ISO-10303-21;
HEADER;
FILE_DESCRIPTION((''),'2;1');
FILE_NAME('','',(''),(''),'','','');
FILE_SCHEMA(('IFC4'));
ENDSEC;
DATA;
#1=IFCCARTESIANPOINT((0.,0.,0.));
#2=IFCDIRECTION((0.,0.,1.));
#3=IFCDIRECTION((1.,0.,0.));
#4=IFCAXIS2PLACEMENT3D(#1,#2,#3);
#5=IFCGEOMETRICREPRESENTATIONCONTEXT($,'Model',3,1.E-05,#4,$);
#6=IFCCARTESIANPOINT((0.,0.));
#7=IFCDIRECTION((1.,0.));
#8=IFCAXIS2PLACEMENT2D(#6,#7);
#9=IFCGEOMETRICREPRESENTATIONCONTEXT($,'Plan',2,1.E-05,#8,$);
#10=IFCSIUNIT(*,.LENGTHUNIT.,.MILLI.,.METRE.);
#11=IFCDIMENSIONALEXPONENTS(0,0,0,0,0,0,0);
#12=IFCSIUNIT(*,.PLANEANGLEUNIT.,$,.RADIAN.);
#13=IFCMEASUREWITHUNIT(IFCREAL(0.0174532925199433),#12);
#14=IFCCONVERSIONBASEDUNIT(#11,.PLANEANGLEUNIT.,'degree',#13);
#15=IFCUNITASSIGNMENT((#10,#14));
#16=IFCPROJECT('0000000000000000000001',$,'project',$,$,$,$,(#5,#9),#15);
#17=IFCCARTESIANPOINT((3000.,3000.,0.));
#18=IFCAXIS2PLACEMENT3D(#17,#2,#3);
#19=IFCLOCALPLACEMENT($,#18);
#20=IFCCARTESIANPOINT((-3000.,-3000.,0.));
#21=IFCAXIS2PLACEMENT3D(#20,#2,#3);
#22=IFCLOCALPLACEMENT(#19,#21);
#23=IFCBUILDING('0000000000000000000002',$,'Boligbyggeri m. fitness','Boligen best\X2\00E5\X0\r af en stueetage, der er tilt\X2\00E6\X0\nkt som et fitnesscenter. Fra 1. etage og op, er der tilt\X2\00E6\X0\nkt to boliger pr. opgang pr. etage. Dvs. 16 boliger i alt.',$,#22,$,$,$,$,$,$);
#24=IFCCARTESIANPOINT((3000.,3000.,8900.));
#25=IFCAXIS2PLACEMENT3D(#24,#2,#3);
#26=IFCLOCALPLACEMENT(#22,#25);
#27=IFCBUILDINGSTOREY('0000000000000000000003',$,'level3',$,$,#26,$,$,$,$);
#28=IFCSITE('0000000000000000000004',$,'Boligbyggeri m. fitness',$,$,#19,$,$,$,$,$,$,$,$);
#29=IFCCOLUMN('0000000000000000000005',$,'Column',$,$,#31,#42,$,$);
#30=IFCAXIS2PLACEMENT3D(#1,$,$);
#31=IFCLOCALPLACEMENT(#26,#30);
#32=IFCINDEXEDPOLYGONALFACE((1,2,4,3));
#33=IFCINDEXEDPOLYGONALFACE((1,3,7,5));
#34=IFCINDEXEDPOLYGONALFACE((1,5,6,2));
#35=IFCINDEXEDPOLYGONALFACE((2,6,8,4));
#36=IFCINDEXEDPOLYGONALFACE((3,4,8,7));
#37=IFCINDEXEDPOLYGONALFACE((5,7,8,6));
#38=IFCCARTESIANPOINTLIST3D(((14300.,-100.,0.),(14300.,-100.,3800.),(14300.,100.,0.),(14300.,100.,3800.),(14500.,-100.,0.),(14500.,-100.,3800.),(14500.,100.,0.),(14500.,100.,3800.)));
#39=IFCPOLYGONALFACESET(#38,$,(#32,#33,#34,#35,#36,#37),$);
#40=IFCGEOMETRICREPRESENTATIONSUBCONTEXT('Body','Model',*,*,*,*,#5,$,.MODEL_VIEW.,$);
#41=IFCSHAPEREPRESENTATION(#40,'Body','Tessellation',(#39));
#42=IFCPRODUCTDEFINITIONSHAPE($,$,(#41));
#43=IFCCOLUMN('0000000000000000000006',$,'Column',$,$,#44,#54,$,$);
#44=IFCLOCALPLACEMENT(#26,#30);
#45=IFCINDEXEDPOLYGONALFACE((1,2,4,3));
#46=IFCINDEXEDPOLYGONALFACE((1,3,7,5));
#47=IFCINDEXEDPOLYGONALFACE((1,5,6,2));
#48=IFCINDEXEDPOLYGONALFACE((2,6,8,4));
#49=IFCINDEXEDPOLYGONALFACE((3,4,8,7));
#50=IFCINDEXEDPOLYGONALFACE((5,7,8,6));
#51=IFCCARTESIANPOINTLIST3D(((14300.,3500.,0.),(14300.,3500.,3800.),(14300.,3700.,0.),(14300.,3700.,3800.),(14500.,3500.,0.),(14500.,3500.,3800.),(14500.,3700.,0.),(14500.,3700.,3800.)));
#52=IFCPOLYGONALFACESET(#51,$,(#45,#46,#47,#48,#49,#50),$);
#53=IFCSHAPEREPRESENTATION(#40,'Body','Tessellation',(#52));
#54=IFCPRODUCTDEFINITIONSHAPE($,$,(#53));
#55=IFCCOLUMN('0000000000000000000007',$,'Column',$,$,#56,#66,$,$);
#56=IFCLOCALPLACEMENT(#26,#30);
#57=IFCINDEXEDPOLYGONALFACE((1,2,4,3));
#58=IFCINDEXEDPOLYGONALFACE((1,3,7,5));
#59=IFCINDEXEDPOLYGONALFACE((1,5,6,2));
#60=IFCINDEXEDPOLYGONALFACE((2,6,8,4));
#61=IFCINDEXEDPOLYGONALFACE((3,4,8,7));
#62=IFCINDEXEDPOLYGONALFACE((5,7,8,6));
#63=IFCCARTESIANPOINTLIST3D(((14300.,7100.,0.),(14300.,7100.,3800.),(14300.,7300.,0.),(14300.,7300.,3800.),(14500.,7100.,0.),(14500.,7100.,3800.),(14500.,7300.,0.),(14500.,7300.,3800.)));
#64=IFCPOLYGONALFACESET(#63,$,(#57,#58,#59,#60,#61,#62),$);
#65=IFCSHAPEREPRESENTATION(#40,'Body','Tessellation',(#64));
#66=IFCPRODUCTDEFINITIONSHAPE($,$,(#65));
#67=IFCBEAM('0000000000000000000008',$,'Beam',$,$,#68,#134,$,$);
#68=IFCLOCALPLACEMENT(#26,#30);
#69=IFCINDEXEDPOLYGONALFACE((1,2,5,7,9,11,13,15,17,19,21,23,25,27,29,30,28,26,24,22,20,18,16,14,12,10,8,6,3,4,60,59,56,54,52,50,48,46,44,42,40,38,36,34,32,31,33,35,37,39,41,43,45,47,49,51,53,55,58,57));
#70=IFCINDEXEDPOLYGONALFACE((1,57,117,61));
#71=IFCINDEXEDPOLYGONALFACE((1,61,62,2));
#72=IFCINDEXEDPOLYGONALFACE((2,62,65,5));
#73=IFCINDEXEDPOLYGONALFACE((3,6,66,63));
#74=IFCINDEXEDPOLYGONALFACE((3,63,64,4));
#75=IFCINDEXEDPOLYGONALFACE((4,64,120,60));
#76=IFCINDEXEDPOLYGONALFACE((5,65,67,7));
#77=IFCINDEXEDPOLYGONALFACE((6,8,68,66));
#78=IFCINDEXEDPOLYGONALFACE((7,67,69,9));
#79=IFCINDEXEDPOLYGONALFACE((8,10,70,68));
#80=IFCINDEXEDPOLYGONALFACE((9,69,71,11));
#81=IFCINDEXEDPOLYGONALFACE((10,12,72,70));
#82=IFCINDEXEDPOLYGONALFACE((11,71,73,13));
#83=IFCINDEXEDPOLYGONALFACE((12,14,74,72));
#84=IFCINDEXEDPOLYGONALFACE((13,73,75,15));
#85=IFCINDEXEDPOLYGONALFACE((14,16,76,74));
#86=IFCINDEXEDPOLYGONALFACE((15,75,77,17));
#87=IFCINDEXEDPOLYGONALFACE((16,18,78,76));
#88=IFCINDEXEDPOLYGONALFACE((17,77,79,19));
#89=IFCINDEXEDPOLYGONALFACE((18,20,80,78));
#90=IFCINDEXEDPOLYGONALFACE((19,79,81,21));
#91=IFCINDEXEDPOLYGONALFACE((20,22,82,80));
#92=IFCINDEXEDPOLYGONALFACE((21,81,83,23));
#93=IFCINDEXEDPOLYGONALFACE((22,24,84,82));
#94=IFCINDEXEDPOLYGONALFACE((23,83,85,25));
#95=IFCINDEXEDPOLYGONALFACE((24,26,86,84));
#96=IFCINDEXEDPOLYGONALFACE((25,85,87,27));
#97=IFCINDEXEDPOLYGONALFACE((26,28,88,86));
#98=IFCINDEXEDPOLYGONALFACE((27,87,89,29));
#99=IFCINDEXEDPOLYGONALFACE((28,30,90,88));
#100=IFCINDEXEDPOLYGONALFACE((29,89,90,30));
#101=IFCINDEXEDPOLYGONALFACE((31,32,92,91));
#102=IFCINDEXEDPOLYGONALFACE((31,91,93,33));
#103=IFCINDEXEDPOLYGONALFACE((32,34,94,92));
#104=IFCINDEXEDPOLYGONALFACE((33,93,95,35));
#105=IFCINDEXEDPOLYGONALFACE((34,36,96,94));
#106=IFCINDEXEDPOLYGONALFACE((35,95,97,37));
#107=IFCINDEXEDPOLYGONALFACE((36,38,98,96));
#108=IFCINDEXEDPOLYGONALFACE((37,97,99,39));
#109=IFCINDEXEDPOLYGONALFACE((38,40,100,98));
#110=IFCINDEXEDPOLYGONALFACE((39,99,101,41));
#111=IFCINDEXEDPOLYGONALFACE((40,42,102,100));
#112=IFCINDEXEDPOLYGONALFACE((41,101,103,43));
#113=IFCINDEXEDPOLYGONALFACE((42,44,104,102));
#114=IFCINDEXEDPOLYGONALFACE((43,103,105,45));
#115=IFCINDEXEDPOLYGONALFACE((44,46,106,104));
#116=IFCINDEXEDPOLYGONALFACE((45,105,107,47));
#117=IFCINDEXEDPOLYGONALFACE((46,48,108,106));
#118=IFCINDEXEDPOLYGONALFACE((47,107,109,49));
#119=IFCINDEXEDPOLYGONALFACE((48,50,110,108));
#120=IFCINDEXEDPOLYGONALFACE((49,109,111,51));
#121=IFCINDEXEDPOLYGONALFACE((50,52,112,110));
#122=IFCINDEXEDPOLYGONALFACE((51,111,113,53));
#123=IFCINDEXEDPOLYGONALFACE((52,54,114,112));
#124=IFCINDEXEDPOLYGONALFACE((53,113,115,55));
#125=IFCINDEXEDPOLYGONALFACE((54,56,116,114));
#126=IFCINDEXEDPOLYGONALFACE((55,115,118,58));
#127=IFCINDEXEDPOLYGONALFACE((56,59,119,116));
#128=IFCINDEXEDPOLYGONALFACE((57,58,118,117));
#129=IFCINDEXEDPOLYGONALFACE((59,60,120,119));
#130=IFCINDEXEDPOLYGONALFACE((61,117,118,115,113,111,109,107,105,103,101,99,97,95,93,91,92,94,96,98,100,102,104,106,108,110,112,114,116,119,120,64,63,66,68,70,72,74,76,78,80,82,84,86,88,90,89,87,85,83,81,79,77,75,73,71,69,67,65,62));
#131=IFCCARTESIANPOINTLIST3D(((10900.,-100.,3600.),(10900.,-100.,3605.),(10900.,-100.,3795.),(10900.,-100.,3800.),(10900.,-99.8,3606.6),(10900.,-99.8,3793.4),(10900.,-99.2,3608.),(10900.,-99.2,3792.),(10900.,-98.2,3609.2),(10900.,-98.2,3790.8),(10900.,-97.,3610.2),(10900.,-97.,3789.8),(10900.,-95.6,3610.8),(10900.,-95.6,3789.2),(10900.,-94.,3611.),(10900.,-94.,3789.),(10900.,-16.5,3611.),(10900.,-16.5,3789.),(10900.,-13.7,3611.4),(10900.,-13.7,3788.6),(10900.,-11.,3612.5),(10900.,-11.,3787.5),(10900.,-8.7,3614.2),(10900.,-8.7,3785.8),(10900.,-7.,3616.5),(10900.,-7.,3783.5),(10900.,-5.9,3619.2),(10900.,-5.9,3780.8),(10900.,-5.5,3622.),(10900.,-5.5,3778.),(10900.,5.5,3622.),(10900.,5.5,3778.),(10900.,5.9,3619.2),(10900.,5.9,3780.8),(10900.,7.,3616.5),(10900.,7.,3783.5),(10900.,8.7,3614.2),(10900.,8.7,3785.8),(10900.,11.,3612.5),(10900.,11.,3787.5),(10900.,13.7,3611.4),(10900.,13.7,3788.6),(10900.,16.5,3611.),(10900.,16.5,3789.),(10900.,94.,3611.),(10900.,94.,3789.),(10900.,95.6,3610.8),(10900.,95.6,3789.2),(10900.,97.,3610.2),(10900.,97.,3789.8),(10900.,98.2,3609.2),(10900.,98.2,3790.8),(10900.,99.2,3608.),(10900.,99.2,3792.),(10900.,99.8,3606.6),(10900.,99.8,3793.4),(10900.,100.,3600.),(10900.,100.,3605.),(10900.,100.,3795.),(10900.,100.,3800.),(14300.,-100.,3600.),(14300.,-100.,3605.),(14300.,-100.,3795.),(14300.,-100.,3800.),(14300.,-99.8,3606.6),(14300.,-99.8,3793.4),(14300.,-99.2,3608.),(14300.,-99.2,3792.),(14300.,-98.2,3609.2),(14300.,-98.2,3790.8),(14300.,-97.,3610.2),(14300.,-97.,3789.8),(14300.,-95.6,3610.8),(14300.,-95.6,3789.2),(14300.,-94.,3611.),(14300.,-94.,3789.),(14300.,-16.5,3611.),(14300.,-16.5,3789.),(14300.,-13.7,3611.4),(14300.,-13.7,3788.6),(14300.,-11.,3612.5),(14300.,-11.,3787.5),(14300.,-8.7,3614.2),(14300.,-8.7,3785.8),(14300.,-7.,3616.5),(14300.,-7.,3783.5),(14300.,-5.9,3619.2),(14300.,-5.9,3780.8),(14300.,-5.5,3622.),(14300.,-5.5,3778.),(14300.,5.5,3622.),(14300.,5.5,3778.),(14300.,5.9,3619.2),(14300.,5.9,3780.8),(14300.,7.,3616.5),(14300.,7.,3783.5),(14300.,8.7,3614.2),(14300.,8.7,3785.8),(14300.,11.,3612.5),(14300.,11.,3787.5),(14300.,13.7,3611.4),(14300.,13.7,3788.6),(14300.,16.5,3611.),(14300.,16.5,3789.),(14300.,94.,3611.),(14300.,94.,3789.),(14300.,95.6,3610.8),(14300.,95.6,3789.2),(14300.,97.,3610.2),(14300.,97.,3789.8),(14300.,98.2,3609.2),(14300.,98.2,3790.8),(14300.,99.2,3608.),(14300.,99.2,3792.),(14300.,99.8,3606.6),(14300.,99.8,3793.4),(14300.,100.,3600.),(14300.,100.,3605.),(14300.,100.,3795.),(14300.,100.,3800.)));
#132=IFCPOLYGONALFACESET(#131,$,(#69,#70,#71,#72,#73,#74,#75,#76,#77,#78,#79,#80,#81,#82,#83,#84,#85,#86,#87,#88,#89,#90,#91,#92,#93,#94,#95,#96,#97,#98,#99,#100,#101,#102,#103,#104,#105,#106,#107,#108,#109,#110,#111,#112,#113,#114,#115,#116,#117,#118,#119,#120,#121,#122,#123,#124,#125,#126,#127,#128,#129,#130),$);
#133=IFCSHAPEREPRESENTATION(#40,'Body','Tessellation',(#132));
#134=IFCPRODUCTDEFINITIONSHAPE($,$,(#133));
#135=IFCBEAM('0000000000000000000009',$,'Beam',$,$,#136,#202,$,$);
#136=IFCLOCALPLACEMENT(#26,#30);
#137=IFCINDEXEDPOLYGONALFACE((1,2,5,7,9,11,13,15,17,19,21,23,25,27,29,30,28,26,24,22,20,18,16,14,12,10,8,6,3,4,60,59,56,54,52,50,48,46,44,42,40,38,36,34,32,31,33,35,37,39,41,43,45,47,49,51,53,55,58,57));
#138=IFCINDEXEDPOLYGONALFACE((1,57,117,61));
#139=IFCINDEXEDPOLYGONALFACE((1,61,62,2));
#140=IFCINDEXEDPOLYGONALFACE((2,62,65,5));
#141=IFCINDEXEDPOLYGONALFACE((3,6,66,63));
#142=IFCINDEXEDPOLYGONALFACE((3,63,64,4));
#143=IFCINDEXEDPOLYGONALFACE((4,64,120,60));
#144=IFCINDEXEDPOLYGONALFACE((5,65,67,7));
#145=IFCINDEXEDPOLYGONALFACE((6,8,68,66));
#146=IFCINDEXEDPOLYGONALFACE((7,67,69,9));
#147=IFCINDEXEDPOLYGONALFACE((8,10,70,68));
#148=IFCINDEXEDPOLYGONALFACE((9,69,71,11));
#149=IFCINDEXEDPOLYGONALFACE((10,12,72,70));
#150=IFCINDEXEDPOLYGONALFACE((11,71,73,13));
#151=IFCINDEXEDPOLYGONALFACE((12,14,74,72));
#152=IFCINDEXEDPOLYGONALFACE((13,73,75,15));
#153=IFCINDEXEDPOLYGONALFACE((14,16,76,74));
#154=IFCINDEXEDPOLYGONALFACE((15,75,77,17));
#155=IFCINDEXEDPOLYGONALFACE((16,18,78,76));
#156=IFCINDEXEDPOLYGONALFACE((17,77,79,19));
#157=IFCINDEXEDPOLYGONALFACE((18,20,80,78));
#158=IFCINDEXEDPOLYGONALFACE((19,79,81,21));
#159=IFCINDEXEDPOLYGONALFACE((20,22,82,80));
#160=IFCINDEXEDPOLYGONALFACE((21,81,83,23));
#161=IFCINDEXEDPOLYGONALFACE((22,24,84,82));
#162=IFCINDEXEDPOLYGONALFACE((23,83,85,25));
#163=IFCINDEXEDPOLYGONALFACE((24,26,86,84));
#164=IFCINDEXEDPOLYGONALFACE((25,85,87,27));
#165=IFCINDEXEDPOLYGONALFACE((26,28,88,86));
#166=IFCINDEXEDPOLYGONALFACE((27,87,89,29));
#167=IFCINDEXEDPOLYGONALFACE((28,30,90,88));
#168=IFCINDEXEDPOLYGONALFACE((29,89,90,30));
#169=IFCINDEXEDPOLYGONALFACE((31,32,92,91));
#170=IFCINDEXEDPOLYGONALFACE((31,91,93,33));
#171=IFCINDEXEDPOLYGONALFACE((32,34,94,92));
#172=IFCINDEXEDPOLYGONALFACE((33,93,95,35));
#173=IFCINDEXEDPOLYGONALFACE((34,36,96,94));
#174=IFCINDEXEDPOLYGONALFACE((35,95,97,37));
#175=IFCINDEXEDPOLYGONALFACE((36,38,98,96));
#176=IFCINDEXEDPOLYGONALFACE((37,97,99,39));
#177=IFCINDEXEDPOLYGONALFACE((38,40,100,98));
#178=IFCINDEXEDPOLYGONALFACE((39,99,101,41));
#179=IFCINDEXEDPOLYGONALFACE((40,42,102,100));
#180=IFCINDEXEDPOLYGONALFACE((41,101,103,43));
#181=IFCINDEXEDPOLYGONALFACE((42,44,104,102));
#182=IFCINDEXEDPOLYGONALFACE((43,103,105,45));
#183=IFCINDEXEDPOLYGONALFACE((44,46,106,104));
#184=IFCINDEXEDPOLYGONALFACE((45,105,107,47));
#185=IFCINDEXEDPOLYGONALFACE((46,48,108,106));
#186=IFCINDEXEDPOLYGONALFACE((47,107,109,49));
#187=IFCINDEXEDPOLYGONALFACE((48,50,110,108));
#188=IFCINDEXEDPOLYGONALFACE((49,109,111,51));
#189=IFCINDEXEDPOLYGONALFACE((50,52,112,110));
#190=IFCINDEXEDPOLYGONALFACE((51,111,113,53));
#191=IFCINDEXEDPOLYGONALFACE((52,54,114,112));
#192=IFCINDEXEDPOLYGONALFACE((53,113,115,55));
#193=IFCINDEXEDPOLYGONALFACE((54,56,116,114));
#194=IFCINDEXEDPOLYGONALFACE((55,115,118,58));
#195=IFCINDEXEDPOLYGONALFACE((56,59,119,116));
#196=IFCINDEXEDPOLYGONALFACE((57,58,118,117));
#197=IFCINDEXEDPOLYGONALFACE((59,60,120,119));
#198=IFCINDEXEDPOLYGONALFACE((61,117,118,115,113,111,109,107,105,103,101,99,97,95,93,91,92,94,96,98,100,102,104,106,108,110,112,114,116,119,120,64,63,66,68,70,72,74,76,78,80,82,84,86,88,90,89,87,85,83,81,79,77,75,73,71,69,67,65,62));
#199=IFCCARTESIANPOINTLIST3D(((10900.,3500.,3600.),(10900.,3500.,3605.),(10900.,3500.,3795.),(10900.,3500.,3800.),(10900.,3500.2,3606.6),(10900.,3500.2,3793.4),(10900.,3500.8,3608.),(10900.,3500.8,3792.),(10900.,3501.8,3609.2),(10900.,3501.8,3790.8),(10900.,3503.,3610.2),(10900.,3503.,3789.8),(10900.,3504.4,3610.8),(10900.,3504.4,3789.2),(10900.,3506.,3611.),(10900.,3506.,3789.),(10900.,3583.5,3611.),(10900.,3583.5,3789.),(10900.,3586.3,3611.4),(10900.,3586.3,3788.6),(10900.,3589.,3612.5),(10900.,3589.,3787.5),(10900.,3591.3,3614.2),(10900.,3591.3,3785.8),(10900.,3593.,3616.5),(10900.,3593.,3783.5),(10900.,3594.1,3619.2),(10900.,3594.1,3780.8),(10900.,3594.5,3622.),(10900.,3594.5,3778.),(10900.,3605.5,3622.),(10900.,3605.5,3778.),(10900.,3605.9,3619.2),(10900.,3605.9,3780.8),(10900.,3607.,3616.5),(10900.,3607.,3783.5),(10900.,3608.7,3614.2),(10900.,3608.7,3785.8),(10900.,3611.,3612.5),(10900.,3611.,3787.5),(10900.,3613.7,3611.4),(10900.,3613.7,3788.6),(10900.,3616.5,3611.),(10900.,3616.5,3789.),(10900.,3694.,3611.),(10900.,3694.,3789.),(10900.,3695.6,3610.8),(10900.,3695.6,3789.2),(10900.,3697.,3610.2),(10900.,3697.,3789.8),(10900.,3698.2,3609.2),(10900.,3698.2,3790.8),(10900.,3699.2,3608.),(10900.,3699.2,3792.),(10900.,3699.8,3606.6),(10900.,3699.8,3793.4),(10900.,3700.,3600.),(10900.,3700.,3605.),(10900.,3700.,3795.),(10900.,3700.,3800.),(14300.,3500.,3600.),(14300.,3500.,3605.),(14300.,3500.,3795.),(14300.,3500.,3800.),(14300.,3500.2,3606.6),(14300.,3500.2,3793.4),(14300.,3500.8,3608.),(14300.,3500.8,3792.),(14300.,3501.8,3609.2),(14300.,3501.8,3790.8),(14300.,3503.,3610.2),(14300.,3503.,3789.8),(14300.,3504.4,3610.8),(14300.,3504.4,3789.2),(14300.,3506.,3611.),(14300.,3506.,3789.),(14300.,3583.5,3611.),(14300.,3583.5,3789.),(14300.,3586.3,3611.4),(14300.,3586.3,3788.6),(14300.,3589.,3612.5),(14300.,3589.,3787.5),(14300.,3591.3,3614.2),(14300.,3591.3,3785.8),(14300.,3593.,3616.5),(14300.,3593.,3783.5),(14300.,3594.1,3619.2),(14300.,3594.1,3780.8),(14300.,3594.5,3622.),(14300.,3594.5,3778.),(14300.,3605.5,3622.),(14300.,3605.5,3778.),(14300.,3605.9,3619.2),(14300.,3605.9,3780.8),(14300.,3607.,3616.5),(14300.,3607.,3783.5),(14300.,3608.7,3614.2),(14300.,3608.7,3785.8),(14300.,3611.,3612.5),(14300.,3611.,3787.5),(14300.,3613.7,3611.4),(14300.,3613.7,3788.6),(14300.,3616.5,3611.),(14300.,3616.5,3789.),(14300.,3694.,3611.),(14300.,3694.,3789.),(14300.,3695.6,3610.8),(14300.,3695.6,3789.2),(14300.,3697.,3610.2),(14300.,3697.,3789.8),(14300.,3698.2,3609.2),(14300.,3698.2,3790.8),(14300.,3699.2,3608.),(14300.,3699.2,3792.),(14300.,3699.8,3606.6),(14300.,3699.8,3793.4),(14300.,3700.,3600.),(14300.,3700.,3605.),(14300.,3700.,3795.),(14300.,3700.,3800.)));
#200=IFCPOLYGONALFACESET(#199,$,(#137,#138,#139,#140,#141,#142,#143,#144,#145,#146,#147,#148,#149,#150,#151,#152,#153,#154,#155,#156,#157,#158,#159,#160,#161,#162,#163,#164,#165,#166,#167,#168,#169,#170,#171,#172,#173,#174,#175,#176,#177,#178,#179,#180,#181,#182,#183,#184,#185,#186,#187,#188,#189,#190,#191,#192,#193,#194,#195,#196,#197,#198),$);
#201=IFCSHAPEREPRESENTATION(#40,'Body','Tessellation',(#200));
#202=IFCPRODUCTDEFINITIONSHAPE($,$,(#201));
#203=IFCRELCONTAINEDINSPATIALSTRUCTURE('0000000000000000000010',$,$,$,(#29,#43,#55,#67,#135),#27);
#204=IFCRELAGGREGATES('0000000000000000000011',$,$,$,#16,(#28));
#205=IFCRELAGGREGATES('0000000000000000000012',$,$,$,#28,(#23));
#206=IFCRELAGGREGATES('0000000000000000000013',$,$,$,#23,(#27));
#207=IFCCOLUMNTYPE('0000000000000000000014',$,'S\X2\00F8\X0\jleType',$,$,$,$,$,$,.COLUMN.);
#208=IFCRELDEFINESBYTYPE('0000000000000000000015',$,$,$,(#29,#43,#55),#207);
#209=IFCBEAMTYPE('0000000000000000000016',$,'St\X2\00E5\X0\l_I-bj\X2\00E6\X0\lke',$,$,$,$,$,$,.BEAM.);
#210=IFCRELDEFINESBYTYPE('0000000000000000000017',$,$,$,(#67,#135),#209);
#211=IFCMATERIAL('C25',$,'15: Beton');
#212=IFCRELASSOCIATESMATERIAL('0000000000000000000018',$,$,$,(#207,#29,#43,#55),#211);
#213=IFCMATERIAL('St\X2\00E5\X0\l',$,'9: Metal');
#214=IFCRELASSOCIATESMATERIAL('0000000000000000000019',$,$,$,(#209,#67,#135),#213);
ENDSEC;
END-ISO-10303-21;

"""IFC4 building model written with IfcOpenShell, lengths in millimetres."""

from ifc_helpers import new_model, entity, si_unit, converted_unit, frame, origin_with_axes, origin_2d_with_axis, place, context, subcontext, project, spatial, rectangle, i_section, extrude, material, material_profile, profile_set, profile_usage, type_object, element, save


model = new_model("IFC4")

# Units and contexts
model_context = context("Model", 3, precision=1e-05, world=origin_with_axes())
plan_context = context("Plan", 2, precision=1e-05, world=origin_2d_with_axis())
body_context = subcontext(model_context, "Body", "Model", "MODEL_VIEW")
ifc_project = project(units=[si_unit("LENGTHUNIT", "METRE", prefix="MILLI"), converted_unit("PLANEANGLEUNIT", "degree", entity("IfcReal", 0.0174532925199433), si_unit("PLANEANGLEUNIT", "RADIAN"), dimensions=[0, 0, 0, 0, 0, 0, 0])], contexts=[model_context, plan_context])

# Site, building, storey
site_placement = place(None, frame((3000.0, 3000.0, 0.0), z_axis=(0.0, 0.0, 1.0), x_axis=(1.0, 0.0, 0.0)))
site = spatial("IfcSite", under=ifc_project, at=site_placement, Name="Boligbyggeri m. fitness")
building_placement = place(site_placement, frame((-3000.0, -3000.0, 0.0), z_axis=(0.0, 0.0, 1.0), x_axis=(1.0, 0.0, 0.0)))
building = spatial("IfcBuilding", under=site, at=building_placement, Name="Boligbyggeri m. fitness", Description="Boligen består af en stueetage, der er tiltænkt som et fitnesscenter. Fra 1. etage og op, er der tiltænkt to boliger pr. opgang pr. etage. Dvs. 16 boliger i alt.")
storey_placement = place(building_placement, frame((3000.0, 3000.0, 8900.0), z_axis=(0.0, 0.0, 1.0), x_axis=(1.0, 0.0, 0.0)))
storey = spatial("IfcBuildingStorey", under=building, at=storey_placement, Name="level3")

# Columns
ifc_material_1 = material(Name="C25", Category="15: Beton")
ifc_material_profile_1 = material_profile(ifc_material_1, rectangle(XDim=200.0, YDim=200.0), Name="SøjleBeton", Category="15: Beton")
ifc_profile_set_1 = profile_set([ifc_material_profile_1], Name="200x200")
ifc_profile_usage_1 = profile_usage(ifc_profile_set_1, cardinal=5)
column_type = type_object("IfcColumnType", Name="SøjleType", PredefinedType="COLUMN", material=ifc_profile_set_1)
column_1_placement = place(storey_placement, frame((14400.0, 0.0, 0.0), z_axis=(0.0, 0.0, 1.0), x_axis=(1.0, 0.0, 0.0)))
element("IfcColumn", 1, at=column_1_placement, inside=storey, type_object=column_type, material=ifc_profile_usage_1, Name="Column", context=body_context, shape_type="SweptSolid", body=[
    extrude(rectangle(XDim=200.0, YDim=200.0), origin_with_axes(), (0.0, 0.0, 1.0), 3800.0),
])
ifc_profile_usage_2 = profile_usage(ifc_profile_set_1, cardinal=5)
column_2_placement = place(storey_placement, frame((14400.0, 3600.0, 0.0), z_axis=(0.0, 0.0, 1.0), x_axis=(1.0, 0.0, 0.0)))
element("IfcColumn", 2, at=column_2_placement, inside=storey, type_object=column_type, material=ifc_profile_usage_2, Name="Column", context=body_context, shape_type="SweptSolid", body=[
    extrude(rectangle(XDim=200.0, YDim=200.0), origin_with_axes(), (0.0, 0.0, 1.0), 3800.0),
])
ifc_profile_usage_3 = profile_usage(ifc_profile_set_1, cardinal=5)
column_3_placement = place(storey_placement, frame((14400.0, 7200.0, 0.0), z_axis=(0.0, 0.0, 1.0), x_axis=(1.0, 0.0, 0.0)))
element("IfcColumn", 3, at=column_3_placement, inside=storey, type_object=column_type, material=ifc_profile_usage_3, Name="Column", context=body_context, shape_type="SweptSolid", body=[
    extrude(rectangle(XDim=200.0, YDim=200.0), origin_with_axes(), (0.0, 0.0, 1.0), 3800.0),
])

# Beams
ifc_material_2 = material(Name="Stål", Category="9: Metal")
ifc_material_profile_2 = material_profile(ifc_material_2, i_section(OverallWidth=200.0, OverallDepth=200.0, WebThickness=11.0, FlangeThickness=11.0, FilletRadius=11.0, FlangeEdgeRadius=6.0), Name="Stål", Category="9: Metal")
ifc_profile_set_2 = profile_set([ifc_material_profile_2], Name="NY_I-Profil")
ifc_profile_usage_4 = profile_usage(ifc_profile_set_2, cardinal=7)
beam_type = type_object("IfcBeamType", Name="Stål_I-bjælke", PredefinedType="BEAM", material=ifc_profile_set_2)
beam_1_placement = place(storey_placement, frame((10900.0, 100.0, 3800.0), z_axis=(1.0, 0.0, 0.0), x_axis=(0.0, 1.0, 0.0)))
element("IfcBeam", 4, at=beam_1_placement, inside=storey, type_object=beam_type, material=ifc_profile_usage_4, Name="Beam", context=body_context, shape_type="SweptSolid", body=[
    extrude(i_section(OverallWidth=200.0, OverallDepth=200.0, WebThickness=11.0, FlangeThickness=11.0, FilletRadius=11.0, FlangeEdgeRadius=6.0), frame((-100.0, -100.0, 0.0), z_axis=(0.0, 0.0, 1.0), x_axis=(1.0, 0.0, 0.0)), (0.0, 0.0, 1.0), 3400.0),
])
ifc_profile_usage_5 = profile_usage(ifc_profile_set_2, cardinal=7)
beam_2_placement = place(storey_placement, frame((10900.0, 3700.0, 3800.0), z_axis=(1.0, 0.0, 0.0), x_axis=(0.0, 1.0, 0.0)))
element("IfcBeam", 5, at=beam_2_placement, inside=storey, type_object=beam_type, material=ifc_profile_usage_5, Name="Beam", context=body_context, shape_type="SweptSolid", body=[
    extrude(i_section(OverallWidth=200.0, OverallDepth=200.0, WebThickness=11.0, FlangeThickness=11.0, FilletRadius=11.0, FlangeEdgeRadius=6.0), frame((-100.0, -100.0, 0.0), z_axis=(0.0, 0.0, 1.0), x_axis=(1.0, 0.0, 0.0)), (0.0, 0.0, 1.0), 3400.0),
])

save(model, "model.ifc")
